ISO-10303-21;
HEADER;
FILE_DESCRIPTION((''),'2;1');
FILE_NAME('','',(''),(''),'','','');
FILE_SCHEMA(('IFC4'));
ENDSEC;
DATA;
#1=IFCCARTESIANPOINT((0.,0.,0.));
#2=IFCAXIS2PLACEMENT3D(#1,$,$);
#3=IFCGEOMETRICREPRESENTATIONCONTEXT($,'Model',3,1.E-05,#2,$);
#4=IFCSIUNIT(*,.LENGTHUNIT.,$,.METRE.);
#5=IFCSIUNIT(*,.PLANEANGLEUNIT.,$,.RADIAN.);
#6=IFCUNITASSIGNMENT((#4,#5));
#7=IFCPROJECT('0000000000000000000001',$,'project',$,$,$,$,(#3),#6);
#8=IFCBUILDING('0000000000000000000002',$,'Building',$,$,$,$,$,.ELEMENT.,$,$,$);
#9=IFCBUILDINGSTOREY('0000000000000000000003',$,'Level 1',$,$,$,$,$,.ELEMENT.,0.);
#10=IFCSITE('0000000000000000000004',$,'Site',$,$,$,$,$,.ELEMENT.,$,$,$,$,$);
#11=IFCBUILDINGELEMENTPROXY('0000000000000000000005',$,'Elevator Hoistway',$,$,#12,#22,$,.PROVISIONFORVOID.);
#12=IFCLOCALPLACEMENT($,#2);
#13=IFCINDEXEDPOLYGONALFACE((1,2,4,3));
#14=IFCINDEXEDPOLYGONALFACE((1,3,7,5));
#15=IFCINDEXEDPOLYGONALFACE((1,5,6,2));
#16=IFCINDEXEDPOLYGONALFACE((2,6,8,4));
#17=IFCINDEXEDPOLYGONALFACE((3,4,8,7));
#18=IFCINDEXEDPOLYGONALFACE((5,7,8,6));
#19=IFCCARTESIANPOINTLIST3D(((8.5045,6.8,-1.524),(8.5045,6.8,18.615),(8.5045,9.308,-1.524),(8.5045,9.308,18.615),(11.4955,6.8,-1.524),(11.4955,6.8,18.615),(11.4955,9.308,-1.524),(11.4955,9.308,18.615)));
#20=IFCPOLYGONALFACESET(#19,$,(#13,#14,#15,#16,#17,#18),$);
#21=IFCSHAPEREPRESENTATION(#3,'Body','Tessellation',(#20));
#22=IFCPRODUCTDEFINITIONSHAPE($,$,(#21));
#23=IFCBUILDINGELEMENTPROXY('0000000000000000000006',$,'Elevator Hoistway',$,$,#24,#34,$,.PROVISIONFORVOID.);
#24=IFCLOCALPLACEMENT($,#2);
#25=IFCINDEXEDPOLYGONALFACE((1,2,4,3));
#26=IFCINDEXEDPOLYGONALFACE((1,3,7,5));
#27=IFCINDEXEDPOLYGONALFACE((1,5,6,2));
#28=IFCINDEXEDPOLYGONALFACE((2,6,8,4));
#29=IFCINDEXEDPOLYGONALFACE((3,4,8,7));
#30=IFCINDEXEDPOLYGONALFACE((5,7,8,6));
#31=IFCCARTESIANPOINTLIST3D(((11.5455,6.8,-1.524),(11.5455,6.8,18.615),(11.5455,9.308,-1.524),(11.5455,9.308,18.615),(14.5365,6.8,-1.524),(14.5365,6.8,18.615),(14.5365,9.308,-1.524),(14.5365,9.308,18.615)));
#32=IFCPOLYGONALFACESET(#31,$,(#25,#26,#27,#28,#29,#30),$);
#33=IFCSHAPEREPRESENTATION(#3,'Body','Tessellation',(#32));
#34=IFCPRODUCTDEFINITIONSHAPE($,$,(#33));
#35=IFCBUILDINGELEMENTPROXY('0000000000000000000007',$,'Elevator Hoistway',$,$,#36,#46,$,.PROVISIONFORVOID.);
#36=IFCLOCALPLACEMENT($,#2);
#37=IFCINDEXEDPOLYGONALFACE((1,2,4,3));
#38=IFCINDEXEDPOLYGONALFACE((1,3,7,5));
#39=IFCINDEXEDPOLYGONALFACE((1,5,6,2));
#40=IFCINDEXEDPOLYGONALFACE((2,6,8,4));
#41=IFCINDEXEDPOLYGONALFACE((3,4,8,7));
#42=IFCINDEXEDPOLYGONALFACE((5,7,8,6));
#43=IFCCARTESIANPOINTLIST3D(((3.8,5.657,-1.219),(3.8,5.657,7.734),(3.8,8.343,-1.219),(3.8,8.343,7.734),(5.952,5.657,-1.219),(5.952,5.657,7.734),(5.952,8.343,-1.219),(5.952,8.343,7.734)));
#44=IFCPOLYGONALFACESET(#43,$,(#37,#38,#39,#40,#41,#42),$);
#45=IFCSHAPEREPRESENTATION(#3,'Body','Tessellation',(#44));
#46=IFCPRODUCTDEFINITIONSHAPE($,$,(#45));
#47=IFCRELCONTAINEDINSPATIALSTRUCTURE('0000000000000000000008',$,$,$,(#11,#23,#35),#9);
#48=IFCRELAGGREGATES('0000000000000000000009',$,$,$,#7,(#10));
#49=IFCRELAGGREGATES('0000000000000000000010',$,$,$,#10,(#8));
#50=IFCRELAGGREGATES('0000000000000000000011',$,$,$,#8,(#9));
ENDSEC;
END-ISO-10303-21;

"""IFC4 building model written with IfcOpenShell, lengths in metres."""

from ifc_helpers import new_model, si_unit, frame, origin, place, context, project, spatial, polyline, outline, extrude, element, save


model = new_model("IFC4")

# Units and contexts
model_context = context("Model", 3, precision=1e-05, world=origin())
ifc_project = project(units=[si_unit("LENGTHUNIT", "METRE"), si_unit("PLANEANGLEUNIT", "RADIAN")], contexts=[model_context])

# Site, building, storey
site = spatial("IfcSite", under=ifc_project, Name="Site", CompositionType="ELEMENT")
building = spatial("IfcBuilding", under=site, Name="Building", CompositionType="ELEMENT")
storey = spatial("IfcBuildingStorey", under=building, Name="Level 1", CompositionType="ELEMENT", Elevation=0.0)

# Building element proxies
proxy_1_placement = place(None, frame((0.0, 0.0, 18.615)))
element("IfcBuildingElementProxy", 1, at=proxy_1_placement, inside=storey, Name="Elevator Hoistway", PredefinedType="PROVISIONFORVOID", context=model_context, shape_type="SweptSolid", body=[
    extrude(outline(polyline([(8.5045, 6.8), (11.4955, 6.8), (11.4955, 9.308), (8.5045, 9.308), (8.5045, 6.8)])), origin(), (0.0, 0.0, -1.0), 20.139),
])
proxy_2_placement = place(None, frame((0.0, 0.0, 18.615)))
element("IfcBuildingElementProxy", 2, at=proxy_2_placement, inside=storey, Name="Elevator Hoistway", PredefinedType="PROVISIONFORVOID", context=model_context, shape_type="SweptSolid", body=[
    extrude(outline(polyline([(11.5455, 6.8), (14.5365, 6.8), (14.5365, 9.308), (11.5455, 9.308), (11.5455, 6.8)])), origin(), (0.0, 0.0, -1.0), 20.139),
])
proxy_3_placement = place(None, frame((0.0, 0.0, 7.734)))
element("IfcBuildingElementProxy", 3, at=proxy_3_placement, inside=storey, Name="Elevator Hoistway", PredefinedType="PROVISIONFORVOID", context=model_context, shape_type="SweptSolid", body=[
    extrude(outline(polyline([(3.8, 8.343), (3.8, 5.657), (5.952, 5.657), (5.952, 8.343), (3.8, 8.343)])), origin(), (0.0, 0.0, -1.0), 8.953),
])

save(model, "model.ifc")
